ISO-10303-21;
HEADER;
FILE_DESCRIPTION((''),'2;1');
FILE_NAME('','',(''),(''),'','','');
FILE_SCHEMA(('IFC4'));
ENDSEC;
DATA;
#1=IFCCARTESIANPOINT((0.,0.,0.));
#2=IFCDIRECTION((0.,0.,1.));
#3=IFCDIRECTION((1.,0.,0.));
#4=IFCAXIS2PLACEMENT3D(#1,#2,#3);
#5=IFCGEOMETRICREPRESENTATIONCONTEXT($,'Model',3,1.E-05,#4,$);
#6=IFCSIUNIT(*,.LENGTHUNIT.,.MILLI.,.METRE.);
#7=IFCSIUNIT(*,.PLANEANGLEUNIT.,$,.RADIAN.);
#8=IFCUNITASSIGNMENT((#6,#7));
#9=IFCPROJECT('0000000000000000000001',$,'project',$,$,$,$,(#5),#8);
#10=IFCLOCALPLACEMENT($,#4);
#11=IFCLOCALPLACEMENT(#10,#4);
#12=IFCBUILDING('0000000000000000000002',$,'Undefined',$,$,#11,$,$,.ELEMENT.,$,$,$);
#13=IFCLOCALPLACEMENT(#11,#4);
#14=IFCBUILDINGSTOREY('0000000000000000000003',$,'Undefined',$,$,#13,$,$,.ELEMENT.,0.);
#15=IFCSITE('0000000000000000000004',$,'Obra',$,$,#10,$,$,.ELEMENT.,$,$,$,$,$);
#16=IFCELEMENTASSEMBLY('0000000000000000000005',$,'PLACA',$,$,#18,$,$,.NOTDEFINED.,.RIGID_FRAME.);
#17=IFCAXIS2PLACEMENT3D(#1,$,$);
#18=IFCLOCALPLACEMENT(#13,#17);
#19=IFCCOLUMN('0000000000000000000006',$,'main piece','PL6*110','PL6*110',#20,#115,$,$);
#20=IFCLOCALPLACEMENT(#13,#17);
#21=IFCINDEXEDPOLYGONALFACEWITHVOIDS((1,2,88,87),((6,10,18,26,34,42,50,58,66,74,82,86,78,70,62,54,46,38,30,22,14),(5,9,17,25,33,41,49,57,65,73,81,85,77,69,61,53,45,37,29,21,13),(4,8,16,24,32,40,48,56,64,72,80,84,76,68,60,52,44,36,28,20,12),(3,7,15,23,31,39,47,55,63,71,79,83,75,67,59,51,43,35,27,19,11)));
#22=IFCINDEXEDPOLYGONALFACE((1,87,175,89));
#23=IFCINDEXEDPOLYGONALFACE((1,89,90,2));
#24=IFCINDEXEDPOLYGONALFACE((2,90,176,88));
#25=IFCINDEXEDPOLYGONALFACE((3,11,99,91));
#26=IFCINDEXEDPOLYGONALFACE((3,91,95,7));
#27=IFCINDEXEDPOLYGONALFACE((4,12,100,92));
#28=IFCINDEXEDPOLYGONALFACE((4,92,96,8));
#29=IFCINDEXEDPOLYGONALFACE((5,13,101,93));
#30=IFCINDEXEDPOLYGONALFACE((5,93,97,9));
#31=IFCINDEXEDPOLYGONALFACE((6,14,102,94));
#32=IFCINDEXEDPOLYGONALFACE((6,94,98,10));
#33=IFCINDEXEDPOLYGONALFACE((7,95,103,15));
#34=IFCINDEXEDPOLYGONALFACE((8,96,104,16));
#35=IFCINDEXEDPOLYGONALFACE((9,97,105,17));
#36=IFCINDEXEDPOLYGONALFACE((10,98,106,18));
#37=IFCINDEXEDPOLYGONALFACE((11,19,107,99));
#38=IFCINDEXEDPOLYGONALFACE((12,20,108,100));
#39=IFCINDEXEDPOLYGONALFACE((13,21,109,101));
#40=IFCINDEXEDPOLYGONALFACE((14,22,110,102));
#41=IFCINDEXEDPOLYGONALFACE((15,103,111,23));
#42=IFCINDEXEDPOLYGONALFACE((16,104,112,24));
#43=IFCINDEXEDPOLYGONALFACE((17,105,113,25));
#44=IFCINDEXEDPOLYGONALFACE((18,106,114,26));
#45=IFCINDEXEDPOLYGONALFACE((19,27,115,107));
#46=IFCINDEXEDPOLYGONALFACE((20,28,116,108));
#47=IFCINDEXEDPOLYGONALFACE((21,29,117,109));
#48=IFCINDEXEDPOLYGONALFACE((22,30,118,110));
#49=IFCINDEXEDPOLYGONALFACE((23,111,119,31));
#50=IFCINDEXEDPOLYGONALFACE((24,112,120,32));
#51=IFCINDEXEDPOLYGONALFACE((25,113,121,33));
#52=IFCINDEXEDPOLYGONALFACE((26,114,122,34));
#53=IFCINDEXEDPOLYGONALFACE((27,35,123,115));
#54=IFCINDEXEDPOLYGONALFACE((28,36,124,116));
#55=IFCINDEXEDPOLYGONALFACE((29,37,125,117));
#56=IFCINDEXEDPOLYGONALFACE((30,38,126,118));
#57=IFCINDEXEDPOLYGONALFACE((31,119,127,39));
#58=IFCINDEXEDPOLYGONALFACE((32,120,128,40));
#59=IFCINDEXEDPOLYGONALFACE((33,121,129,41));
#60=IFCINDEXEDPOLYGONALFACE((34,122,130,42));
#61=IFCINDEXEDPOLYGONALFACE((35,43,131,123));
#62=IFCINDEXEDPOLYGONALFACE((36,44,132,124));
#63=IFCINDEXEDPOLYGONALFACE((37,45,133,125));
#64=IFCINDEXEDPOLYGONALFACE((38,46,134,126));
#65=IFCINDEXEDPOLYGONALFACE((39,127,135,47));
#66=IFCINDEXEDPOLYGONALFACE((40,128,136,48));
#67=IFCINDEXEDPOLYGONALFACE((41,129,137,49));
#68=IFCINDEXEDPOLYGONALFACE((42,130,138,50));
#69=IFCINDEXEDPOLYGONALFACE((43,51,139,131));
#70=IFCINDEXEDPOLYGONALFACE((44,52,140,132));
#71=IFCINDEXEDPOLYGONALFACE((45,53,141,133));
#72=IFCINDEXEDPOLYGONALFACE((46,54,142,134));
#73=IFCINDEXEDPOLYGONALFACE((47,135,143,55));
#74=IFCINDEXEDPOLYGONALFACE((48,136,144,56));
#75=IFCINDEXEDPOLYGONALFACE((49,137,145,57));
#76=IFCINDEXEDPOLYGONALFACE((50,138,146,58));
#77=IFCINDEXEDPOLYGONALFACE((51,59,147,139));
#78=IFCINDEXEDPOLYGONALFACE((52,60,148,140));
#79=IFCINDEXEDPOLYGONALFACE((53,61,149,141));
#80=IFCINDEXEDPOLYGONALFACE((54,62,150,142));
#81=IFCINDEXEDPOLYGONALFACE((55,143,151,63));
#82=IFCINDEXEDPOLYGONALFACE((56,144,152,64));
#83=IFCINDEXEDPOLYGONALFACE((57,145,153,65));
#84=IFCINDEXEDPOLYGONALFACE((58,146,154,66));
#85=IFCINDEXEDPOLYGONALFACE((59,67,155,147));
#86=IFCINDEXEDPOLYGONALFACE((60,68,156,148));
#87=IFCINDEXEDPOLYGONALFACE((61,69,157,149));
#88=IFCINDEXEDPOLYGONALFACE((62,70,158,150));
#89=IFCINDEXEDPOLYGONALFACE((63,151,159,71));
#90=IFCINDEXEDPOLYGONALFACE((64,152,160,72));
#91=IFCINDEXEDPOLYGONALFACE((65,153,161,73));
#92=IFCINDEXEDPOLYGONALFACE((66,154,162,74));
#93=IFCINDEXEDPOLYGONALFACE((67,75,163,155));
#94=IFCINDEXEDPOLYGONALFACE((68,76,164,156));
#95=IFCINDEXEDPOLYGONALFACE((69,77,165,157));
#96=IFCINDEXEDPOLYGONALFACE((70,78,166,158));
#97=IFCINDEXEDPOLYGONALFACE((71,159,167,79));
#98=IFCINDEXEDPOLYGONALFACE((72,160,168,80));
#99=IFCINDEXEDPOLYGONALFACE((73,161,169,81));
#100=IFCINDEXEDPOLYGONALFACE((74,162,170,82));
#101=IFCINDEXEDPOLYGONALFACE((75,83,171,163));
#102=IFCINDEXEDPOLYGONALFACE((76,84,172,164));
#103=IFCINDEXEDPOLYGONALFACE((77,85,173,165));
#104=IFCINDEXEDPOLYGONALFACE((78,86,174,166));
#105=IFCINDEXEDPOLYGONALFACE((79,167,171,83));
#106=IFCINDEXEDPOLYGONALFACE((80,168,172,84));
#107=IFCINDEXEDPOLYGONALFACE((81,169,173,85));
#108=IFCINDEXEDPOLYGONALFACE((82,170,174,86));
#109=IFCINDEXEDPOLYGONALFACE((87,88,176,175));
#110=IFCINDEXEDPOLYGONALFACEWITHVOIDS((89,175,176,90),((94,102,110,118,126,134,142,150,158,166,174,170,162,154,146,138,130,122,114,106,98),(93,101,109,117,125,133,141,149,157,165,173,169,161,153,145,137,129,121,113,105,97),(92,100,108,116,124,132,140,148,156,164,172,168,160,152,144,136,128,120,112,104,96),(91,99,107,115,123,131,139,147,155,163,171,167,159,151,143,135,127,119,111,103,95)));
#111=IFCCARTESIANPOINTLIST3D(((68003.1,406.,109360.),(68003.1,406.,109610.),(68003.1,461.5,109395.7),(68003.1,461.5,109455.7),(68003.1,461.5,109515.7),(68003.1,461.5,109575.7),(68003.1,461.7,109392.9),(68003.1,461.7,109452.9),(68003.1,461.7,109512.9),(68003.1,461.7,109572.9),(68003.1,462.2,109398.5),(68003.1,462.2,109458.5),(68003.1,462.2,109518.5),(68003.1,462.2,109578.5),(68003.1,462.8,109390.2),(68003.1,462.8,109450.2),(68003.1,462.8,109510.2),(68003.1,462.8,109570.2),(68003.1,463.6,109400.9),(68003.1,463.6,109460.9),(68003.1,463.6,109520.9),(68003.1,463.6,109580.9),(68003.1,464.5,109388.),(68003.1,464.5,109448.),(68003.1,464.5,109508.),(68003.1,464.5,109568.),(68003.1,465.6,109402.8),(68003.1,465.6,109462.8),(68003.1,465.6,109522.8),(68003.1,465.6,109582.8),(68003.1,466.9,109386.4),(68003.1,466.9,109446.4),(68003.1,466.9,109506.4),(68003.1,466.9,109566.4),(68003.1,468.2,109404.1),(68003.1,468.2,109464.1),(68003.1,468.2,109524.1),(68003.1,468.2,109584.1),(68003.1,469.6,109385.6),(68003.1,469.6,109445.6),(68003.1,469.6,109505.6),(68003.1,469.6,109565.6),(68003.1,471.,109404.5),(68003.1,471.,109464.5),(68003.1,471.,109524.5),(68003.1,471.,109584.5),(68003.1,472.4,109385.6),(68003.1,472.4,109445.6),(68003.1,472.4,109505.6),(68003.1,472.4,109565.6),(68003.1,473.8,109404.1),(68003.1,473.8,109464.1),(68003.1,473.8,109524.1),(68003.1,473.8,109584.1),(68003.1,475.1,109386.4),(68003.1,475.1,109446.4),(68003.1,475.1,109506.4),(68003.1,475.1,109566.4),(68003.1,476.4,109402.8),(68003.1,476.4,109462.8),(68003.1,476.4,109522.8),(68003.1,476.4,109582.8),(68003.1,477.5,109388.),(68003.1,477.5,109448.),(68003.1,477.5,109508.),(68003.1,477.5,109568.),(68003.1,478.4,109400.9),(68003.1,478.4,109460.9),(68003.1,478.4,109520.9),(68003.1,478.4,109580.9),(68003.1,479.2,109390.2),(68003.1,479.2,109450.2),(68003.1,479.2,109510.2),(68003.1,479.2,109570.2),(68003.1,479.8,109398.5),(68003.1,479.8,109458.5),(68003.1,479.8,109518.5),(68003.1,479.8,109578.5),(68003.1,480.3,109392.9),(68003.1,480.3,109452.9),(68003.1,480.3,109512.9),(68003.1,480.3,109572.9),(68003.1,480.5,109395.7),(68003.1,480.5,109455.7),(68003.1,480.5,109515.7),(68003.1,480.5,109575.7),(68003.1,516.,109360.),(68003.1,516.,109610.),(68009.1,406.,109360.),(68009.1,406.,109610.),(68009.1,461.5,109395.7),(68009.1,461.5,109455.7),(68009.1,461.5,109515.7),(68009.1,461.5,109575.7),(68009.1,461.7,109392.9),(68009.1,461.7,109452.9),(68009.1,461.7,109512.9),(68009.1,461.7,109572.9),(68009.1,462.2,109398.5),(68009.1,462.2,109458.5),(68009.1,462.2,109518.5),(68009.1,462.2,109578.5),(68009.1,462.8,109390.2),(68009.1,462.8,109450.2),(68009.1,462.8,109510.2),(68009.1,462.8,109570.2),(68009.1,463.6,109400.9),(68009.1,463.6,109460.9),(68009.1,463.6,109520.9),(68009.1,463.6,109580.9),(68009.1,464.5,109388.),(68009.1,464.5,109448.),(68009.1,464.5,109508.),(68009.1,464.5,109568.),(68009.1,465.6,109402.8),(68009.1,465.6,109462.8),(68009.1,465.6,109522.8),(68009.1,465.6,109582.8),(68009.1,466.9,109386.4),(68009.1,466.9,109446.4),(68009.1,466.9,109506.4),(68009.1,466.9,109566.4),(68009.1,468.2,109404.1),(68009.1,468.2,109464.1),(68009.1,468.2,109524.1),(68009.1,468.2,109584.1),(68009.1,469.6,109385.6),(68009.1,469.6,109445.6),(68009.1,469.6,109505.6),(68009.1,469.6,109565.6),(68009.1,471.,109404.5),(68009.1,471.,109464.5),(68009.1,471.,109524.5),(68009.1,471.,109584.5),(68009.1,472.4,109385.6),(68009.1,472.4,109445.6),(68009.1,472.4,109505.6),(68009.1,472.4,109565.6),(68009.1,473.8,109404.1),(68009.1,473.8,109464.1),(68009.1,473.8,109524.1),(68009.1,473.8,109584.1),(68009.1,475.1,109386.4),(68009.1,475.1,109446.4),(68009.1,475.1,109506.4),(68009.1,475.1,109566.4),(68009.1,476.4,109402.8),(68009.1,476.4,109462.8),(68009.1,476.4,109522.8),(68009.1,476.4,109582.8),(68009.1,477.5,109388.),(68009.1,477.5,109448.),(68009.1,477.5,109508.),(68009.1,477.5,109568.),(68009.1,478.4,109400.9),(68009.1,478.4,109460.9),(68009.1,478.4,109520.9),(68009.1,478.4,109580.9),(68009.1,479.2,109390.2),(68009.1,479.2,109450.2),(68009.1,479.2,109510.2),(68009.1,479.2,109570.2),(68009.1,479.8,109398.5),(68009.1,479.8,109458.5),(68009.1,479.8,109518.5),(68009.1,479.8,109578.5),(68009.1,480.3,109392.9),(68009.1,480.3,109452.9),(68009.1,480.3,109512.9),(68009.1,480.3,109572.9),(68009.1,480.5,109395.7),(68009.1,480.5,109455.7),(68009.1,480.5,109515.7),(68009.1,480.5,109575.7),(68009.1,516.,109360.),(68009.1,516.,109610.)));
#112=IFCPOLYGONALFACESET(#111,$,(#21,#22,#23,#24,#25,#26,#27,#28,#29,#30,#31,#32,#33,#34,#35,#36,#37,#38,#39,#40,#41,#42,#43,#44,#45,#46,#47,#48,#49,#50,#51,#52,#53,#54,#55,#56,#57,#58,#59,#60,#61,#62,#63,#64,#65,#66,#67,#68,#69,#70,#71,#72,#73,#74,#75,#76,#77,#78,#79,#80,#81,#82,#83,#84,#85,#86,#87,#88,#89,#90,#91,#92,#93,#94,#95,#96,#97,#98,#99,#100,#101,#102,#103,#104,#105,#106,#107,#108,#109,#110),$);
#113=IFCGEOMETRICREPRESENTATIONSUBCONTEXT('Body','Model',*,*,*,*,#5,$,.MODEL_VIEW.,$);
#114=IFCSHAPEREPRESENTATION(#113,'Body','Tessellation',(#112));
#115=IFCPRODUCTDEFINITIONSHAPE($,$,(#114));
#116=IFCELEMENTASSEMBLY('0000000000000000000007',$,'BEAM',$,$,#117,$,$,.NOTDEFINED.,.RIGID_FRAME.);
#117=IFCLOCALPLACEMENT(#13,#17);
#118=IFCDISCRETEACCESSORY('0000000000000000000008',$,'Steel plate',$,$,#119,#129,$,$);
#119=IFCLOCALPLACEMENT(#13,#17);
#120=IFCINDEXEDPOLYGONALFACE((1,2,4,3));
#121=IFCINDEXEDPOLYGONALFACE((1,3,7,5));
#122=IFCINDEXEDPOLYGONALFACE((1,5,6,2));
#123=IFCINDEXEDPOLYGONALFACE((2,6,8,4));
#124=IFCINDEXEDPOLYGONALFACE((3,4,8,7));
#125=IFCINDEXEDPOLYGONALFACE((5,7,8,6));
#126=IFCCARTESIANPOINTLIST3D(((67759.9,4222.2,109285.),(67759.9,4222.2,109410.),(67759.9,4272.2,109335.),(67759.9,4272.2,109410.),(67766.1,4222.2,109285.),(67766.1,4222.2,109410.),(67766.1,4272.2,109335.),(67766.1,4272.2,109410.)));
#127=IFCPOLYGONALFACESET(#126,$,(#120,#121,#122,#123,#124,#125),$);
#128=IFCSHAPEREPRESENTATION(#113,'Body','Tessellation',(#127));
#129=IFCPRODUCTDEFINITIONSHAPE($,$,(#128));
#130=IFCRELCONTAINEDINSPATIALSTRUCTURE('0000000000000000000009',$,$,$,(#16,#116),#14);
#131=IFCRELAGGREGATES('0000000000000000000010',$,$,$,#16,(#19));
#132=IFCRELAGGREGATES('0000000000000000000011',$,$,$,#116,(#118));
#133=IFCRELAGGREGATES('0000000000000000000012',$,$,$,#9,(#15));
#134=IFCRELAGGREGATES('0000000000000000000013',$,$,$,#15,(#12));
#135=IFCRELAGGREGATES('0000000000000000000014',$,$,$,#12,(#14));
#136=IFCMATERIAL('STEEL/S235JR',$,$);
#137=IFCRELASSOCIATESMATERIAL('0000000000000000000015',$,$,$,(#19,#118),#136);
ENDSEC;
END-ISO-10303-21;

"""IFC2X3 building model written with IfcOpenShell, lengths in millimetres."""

from ifc_helpers import new_model, si_unit, frame, origin_with_axes, origin_2d_with_axis, place, context, subcontext, project, spatial, polyline, rectangle, circle, outline, extrude, source, transform, mapped, material, element, aggregate, save


model = new_model("IFC2X3")

# Units and contexts
model_context = context("Model", 3, precision=1e-05, world=origin_with_axes())
body_context = subcontext(model_context, "Body", "Model", "MODEL_VIEW")
ifc_project = project(units=[si_unit("LENGTHUNIT", "METRE", prefix="MILLI"), si_unit("PLANEANGLEUNIT", "RADIAN")], contexts=[model_context])

# Site, building, storey
site_placement = place(None, origin_with_axes())
site = spatial("IfcSite", under=ifc_project, at=site_placement, Name="Obra", CompositionType="ELEMENT")
building_placement = place(site_placement, origin_with_axes())
building = spatial("IfcBuilding", under=site, at=building_placement, Name="Undefined", CompositionType="ELEMENT")
storey_placement = place(building_placement, origin_with_axes())
storey = spatial("IfcBuildingStorey", under=building, at=storey_placement, Name="Undefined", CompositionType="ELEMENT", Elevation=0.0)

# Shared definitions
ifc_material_1 = material(Name="STEEL/S235JR")

# Element assembly, column, opening
shared_shape_1 = source(origin_with_axes(), body_context, "Body", "SweptSolid", [
    extrude(circle(Radius=9.5, at=origin_2d_with_axis()), frame((0.0, -9.2, 0.0), z_axis=(0.0, 1.0, 0.0), x_axis=(1.0, 0.0, 0.0)), (0.0, 0.0, 1.0), 6.2),
])
assembly_1_placement = place(storey_placement, origin_with_axes())
assembly_1 = element("IfcElementAssembly", 1, at=assembly_1_placement, inside=storey, Name="PLACA", AssemblyPlace="NOTDEFINED", PredefinedType="RIGID_FRAME")
column_1_placement = place(assembly_1_placement, frame((68006.1, 461.0, 109360.0), z_axis=(0.0, 0.0, 1.0), x_axis=(0.0, -1.0, 0.0)))
column_1 = element("IfcColumn", 2, at=column_1_placement, material=ifc_material_1, Name="main piece", Description="PL6*110", ObjectType="PL6*110", context=body_context, shape_type="SweptSolid", body=[
    extrude(rectangle(XDim=6.0, YDim=110.0, at=origin_2d_with_axis()), frame((0.0, 0.0, 250.0), z_axis=(0.0, 0.0, -1.0), x_axis=(0.0, 1.0, 0.0)), (0.0, 0.0, 1.0), 250.0),
])
opening_1_placement = place(assembly_1_placement, frame((68000.0, 471.0, 109395.0), z_axis=(0.0, -1.0, 0.0), x_axis=(0.0, 0.0, 1.0)))
element("IfcOpeningElement", 3, at=opening_1_placement, cuts=column_1, ObjectType="Opening", context=body_context, shape_type="MappedRepresentation", body=[
    mapped(shared_shape_1, transform((0.0, 0.0, 0.0))),
    mapped(shared_shape_1, transform((60.0, 0.0, 0.0))),
    mapped(shared_shape_1, transform((120.0, 0.0, 0.0))),
    mapped(shared_shape_1, transform((180.0, 0.0, 0.0))),
])
aggregate(assembly_1, [column_1])

# Element assembly, discrete accessory
assembly_2_placement = place(storey_placement, origin_with_axes())
assembly_2 = element("IfcElementAssembly", 4, at=assembly_2_placement, inside=storey, Name="BEAM", AssemblyPlace="NOTDEFINED", PredefinedType="RIGID_FRAME")
discrete_accessory_1_placement = place(assembly_2_placement, frame((67763.0, 4222.2, 109410.0), z_axis=(1.0, 0.0, 0.0), x_axis=(0.0, 0.0, -1.0)))
discrete_accessory_1 = element("IfcDiscreteAccessory", 5, at=discrete_accessory_1_placement, material=ifc_material_1, Name="Steel plate", context=body_context, shape_type="SweptSolid", body=[
    extrude(outline(polyline([(0.0, 0.0), (150.0, 0.0), (150.0, -25.0), (75.0, 50.0), (0.0, 50.0), (0.0, 0.0)])), frame((0.0, 0.0, -3.1), z_axis=(0.0, 0.0, 1.0), x_axis=(1.0, 0.0, 0.0)), (0.0, 0.0, 1.0), 6.2),
])

aggregate(assembly_2, [discrete_accessory_1])

save(model, "model.ifc")
